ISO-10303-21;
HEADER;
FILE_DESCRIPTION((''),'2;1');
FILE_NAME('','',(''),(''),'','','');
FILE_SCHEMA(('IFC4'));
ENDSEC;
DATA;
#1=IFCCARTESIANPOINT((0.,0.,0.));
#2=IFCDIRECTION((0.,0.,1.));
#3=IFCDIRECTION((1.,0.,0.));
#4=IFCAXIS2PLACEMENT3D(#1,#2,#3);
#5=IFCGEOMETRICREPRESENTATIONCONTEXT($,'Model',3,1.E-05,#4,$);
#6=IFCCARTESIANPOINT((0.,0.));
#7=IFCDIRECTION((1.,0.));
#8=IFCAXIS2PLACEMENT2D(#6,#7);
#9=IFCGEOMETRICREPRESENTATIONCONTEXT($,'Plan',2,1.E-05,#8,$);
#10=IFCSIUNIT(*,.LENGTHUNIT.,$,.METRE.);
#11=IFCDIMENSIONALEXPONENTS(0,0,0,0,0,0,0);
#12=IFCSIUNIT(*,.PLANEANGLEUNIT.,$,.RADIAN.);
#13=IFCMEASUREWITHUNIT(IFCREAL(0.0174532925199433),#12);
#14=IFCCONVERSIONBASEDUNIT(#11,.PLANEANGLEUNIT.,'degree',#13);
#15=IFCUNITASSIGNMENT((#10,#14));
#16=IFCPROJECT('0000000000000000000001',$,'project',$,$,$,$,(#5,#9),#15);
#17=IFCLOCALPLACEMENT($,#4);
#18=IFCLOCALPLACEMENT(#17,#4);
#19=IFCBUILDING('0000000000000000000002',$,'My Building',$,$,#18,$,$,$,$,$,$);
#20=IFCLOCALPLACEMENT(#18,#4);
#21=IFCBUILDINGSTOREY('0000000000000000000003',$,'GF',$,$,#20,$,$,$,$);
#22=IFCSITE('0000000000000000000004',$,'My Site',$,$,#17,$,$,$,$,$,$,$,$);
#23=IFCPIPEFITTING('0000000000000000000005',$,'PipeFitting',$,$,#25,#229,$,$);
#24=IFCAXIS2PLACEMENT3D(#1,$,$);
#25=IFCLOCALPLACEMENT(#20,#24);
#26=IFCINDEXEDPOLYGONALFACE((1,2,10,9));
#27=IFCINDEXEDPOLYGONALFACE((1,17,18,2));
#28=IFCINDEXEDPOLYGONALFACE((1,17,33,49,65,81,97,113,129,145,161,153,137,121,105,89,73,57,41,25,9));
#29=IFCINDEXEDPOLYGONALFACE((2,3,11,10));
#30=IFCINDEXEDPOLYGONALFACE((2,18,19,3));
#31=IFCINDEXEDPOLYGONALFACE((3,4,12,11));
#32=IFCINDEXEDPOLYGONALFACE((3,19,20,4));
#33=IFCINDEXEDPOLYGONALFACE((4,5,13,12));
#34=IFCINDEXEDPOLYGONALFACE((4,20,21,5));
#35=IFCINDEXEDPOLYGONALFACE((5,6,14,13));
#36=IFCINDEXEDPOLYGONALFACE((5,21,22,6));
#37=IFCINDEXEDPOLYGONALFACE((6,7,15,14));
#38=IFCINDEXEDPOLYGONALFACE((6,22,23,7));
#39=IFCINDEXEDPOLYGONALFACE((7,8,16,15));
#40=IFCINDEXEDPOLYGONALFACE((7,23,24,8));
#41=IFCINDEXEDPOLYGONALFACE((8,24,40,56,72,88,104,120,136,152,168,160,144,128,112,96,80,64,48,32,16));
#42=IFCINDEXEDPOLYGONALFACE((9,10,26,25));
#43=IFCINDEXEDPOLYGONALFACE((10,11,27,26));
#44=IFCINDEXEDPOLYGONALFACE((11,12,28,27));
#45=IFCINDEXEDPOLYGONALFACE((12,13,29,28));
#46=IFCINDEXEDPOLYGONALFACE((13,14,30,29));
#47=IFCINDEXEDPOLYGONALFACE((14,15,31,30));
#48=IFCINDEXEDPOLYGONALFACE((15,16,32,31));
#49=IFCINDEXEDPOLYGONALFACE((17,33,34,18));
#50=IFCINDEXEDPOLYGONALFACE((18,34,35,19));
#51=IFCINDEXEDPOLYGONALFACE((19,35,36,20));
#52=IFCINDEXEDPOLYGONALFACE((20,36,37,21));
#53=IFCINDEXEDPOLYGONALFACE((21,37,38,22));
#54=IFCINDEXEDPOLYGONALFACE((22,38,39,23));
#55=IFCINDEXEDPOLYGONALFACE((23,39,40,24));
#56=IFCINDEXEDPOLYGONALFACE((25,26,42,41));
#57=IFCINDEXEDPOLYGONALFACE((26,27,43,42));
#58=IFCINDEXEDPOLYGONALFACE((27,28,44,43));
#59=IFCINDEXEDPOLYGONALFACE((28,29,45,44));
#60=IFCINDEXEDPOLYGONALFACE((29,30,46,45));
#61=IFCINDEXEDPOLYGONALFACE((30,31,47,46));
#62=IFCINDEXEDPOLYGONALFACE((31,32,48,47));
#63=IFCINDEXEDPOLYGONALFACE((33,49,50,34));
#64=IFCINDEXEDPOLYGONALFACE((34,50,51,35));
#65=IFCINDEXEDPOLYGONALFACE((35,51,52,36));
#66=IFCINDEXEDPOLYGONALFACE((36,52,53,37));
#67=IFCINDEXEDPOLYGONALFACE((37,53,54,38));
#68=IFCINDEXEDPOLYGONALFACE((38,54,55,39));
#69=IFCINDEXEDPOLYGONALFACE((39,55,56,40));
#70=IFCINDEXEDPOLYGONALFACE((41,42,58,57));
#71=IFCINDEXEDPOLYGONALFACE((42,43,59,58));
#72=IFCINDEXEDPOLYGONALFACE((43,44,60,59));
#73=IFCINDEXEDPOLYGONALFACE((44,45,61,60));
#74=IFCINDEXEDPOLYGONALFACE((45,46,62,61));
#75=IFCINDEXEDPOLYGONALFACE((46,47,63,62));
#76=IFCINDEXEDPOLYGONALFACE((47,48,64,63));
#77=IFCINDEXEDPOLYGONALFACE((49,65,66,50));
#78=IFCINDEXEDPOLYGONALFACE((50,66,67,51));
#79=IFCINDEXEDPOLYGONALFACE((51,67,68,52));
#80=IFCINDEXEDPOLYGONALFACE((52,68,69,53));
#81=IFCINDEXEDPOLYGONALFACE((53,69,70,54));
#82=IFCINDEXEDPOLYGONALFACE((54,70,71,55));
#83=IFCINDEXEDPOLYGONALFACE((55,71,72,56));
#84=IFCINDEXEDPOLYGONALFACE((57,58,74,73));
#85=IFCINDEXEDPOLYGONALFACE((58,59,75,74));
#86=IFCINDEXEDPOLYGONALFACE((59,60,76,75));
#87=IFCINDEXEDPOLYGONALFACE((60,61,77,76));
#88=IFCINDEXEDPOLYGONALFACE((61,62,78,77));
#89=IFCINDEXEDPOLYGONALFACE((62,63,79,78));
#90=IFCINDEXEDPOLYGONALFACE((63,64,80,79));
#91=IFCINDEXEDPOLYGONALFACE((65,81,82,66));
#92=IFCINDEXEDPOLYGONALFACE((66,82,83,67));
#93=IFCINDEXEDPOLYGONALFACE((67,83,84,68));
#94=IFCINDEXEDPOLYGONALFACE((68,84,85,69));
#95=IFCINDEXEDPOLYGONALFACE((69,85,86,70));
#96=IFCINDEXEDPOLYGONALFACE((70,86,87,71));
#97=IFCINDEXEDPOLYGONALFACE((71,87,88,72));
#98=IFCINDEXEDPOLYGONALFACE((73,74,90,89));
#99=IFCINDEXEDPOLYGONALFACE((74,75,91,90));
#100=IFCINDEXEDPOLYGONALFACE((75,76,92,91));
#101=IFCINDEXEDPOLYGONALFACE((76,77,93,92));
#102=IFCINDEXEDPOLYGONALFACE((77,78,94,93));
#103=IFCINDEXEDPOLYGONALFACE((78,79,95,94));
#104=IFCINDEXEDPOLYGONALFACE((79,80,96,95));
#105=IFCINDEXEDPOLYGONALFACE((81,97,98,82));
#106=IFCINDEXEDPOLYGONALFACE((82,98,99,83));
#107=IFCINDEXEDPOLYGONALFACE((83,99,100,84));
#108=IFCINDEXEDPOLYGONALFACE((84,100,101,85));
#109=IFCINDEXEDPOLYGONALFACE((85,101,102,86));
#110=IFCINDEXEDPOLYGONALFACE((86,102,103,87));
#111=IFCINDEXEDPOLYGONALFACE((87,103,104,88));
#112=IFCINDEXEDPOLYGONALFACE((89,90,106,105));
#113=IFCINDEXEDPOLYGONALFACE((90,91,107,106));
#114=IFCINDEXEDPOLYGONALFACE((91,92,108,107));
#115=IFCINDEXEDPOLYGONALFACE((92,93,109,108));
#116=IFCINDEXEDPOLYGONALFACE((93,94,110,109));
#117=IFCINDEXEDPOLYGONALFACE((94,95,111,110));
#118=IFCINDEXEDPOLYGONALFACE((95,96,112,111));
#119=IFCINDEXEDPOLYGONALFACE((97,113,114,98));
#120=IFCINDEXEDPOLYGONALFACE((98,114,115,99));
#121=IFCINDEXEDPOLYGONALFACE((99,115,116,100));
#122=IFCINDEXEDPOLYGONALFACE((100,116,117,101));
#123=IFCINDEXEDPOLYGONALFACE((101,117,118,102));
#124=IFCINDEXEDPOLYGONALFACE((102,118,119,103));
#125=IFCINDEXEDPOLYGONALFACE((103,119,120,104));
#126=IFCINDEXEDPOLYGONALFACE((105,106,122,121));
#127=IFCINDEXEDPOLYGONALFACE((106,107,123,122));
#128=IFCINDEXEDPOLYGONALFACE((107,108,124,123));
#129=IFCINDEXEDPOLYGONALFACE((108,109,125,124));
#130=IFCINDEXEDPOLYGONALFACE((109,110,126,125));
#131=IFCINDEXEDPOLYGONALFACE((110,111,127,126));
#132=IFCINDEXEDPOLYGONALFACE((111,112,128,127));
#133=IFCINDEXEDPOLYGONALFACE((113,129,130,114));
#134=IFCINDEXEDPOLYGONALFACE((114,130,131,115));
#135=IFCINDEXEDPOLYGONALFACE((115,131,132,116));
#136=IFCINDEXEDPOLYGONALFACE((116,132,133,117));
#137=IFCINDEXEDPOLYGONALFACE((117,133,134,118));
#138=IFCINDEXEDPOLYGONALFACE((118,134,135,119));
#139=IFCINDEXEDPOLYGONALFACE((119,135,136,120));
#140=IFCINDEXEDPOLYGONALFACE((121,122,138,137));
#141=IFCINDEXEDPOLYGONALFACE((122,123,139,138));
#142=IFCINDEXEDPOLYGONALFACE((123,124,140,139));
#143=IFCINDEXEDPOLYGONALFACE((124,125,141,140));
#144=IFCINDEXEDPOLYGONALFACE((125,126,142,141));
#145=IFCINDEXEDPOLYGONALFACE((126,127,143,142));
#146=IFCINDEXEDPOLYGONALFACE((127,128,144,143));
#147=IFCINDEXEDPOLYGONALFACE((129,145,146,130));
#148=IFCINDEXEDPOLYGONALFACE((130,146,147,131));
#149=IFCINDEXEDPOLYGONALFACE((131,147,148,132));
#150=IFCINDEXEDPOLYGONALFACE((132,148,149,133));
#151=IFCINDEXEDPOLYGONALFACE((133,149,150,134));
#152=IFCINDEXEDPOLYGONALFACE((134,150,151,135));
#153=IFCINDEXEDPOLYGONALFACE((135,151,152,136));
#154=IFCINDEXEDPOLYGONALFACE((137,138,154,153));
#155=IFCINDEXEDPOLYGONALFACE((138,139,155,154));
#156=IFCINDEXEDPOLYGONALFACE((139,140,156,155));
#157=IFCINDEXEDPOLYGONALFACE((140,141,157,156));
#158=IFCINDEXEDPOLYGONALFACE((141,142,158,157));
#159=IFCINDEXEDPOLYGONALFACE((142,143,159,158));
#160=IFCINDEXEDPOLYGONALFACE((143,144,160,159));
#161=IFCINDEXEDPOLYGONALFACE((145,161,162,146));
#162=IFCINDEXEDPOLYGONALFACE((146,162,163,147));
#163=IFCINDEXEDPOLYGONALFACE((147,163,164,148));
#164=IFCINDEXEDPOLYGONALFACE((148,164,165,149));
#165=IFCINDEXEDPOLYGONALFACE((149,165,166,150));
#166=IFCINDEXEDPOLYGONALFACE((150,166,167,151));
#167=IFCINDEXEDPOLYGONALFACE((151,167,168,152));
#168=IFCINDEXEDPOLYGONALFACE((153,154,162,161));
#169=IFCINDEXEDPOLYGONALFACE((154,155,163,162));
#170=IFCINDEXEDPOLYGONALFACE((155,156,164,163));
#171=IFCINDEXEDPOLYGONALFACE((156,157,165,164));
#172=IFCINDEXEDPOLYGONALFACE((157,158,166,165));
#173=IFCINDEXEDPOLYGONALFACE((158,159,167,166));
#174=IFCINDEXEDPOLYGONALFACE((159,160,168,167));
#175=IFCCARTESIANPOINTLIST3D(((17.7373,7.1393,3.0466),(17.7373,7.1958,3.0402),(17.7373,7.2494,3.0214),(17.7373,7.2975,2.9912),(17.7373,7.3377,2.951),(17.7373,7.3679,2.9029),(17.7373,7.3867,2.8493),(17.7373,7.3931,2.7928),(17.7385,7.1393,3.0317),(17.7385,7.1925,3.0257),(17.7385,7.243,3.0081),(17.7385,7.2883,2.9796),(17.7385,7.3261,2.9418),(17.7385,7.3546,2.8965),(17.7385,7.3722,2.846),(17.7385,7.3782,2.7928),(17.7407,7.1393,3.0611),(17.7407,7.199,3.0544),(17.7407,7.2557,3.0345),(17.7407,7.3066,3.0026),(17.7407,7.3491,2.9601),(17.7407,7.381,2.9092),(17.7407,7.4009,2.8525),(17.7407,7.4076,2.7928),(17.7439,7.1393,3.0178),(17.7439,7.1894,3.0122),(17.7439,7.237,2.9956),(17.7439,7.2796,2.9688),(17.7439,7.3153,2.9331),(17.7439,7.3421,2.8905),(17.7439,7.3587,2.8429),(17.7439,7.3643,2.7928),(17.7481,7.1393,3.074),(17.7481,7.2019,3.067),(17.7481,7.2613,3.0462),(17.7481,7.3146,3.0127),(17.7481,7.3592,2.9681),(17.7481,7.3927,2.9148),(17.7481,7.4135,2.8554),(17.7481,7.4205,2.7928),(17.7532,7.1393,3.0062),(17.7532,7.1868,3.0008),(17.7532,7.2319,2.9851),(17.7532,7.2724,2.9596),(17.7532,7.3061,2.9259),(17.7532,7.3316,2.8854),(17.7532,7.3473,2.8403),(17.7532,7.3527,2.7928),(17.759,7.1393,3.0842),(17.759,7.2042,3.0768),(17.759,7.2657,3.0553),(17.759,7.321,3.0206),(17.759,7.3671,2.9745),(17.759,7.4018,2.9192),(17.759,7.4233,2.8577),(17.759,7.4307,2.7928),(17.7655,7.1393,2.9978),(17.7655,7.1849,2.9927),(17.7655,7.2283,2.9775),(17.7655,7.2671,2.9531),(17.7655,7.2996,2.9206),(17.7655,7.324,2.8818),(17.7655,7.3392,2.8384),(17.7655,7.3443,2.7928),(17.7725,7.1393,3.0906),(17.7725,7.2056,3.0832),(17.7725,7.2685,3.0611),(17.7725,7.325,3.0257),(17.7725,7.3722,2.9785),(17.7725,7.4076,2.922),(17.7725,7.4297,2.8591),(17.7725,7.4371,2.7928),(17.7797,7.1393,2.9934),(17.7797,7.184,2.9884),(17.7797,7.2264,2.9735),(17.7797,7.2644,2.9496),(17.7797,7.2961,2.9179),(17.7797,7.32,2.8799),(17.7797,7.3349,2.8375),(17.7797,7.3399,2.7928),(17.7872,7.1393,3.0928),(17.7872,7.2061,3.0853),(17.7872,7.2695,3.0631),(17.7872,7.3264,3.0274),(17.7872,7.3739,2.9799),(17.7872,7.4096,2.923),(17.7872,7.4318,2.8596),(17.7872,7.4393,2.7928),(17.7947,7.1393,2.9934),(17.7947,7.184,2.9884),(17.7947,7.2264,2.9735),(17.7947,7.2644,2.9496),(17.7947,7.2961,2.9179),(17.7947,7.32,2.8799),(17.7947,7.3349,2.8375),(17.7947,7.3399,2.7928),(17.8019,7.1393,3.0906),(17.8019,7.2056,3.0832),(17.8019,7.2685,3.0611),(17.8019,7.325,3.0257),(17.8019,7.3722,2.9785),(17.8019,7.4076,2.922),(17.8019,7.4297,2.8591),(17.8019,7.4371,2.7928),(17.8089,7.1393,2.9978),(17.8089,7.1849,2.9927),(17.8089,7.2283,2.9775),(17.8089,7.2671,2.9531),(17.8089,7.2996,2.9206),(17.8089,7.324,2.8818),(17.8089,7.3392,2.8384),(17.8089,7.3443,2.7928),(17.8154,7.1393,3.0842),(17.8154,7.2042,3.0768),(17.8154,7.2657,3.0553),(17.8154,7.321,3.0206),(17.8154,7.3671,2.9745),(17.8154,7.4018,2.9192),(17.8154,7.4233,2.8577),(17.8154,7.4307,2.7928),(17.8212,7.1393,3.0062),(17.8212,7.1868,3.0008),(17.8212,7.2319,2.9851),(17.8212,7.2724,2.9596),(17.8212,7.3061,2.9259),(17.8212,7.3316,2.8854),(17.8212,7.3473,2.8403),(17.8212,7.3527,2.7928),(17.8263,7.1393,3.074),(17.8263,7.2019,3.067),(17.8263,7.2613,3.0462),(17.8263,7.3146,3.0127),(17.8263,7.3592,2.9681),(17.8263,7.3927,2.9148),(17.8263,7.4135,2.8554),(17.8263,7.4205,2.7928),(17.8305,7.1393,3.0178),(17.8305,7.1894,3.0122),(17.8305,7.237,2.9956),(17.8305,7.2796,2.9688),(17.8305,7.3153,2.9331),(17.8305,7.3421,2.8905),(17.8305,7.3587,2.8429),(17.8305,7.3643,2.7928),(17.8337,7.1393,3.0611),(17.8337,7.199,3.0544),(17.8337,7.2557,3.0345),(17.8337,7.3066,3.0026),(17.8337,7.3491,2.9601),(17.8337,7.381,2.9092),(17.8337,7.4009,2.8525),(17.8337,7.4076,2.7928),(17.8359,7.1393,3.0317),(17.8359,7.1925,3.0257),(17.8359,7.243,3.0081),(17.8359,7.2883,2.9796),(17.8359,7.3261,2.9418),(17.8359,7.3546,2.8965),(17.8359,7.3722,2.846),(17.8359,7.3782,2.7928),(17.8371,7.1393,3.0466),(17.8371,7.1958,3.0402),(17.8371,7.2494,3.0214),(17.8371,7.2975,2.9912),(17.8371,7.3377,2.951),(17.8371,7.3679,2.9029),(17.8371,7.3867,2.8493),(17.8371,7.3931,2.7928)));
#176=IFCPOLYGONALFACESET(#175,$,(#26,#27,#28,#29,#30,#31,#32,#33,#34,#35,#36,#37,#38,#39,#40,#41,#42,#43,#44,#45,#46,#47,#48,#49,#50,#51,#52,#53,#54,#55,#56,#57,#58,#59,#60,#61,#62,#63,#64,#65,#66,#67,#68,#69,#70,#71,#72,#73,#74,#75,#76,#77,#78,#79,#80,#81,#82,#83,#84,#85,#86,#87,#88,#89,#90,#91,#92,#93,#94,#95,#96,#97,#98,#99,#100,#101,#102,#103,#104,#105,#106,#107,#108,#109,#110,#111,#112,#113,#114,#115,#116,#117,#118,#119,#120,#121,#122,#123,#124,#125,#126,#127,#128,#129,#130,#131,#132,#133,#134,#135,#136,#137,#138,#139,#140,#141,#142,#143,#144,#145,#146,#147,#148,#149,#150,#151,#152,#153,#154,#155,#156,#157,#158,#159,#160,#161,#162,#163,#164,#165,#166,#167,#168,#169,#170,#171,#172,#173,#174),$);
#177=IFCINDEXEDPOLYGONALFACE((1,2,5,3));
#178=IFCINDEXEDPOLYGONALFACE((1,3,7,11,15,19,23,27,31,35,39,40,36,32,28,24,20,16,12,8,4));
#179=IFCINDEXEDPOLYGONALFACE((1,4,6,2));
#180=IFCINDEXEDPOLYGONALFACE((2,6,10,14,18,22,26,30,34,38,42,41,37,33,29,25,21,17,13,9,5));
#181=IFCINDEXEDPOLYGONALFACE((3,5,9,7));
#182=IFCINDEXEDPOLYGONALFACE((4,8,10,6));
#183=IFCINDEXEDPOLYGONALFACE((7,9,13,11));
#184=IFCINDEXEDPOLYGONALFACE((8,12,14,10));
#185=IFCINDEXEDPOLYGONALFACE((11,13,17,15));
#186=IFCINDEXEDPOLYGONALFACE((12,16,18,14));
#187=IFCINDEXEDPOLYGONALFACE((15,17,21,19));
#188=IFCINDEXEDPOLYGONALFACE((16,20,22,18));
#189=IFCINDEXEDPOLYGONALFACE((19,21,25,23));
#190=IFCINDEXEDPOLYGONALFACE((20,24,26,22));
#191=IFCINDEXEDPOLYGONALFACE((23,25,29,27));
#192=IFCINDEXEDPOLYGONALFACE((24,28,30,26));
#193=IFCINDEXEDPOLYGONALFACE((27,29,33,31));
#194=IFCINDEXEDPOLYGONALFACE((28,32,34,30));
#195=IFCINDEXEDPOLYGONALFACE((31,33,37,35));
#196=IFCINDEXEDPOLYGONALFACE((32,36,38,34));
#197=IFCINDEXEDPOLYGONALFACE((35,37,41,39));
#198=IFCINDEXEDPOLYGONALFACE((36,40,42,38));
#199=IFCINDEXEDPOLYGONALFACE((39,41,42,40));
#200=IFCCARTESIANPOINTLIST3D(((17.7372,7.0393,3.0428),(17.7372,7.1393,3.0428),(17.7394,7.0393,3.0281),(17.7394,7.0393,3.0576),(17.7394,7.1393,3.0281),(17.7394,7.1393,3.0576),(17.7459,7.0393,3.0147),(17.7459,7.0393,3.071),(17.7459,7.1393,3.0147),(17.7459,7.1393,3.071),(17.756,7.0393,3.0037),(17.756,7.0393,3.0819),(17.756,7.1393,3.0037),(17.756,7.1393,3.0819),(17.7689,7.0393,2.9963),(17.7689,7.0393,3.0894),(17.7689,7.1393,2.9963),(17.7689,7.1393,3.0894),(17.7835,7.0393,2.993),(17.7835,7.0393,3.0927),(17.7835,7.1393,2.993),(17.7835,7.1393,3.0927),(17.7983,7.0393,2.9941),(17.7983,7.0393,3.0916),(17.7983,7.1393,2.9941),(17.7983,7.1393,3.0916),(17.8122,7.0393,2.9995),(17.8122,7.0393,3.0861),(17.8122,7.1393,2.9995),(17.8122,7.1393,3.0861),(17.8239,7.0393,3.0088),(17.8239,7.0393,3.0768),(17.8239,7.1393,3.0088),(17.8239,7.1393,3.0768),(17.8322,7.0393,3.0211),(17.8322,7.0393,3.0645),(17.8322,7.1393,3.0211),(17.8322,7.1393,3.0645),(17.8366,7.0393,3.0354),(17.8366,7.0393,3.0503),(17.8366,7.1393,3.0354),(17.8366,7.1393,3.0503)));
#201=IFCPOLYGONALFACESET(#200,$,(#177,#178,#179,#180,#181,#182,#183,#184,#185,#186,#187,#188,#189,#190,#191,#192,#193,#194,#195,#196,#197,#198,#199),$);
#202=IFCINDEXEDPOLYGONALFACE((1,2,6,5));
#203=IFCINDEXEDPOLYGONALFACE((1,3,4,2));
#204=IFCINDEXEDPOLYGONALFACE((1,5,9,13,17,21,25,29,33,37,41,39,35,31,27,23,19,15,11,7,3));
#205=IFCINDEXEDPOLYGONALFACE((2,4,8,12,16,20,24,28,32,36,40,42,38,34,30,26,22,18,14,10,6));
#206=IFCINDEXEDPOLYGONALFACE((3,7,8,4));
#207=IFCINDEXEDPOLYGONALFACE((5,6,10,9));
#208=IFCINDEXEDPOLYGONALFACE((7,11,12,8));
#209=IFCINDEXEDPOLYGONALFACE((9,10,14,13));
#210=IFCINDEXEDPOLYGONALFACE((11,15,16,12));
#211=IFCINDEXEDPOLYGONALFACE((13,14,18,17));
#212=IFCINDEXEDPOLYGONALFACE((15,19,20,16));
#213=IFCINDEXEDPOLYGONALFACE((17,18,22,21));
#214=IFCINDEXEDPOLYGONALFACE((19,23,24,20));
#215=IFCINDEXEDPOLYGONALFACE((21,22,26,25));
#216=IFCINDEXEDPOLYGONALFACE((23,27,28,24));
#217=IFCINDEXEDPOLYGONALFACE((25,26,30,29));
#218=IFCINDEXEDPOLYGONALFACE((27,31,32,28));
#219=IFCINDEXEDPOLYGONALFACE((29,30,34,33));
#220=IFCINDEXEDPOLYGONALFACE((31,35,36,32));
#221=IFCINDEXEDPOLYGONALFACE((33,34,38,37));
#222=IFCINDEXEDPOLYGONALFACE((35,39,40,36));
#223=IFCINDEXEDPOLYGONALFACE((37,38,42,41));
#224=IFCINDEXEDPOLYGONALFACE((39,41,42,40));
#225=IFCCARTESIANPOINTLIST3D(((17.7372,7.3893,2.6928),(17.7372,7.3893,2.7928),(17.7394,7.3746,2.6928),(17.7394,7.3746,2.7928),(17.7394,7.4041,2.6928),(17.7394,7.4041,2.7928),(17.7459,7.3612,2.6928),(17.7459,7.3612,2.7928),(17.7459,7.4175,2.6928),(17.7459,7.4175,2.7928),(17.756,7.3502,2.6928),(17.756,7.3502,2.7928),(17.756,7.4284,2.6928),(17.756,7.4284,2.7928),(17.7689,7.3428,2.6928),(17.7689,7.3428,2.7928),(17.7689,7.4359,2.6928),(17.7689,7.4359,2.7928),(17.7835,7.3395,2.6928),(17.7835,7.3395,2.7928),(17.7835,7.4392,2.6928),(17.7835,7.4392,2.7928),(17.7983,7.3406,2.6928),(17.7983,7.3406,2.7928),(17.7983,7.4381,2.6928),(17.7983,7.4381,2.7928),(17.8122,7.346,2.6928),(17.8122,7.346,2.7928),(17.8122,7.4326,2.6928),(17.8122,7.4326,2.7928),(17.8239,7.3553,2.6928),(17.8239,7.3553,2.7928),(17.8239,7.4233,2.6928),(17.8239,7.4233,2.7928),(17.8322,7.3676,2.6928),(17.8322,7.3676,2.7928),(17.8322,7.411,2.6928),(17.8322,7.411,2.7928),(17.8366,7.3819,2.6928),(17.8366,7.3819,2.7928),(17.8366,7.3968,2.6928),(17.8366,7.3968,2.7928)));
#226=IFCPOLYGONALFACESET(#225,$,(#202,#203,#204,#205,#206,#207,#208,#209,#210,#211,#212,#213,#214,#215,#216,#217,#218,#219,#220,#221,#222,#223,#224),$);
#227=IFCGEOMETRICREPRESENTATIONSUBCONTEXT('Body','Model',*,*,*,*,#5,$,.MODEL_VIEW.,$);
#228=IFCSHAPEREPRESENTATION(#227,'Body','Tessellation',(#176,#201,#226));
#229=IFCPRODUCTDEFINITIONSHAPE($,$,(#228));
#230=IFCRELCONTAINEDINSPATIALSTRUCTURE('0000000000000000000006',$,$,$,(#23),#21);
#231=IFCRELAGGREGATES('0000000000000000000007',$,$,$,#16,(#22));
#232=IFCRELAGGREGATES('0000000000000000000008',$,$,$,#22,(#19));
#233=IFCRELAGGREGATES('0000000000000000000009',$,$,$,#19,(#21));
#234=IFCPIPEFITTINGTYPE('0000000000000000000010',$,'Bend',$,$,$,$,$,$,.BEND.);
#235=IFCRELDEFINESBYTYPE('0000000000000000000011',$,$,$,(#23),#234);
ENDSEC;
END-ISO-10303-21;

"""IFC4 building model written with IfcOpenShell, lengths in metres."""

from ifc_helpers import new_model, entity, si_unit, converted_unit, frame, origin_with_axes, origin_2d_with_axis, place, context, subcontext, project, spatial, line, indexed_curve, circle, outline, extrude, source, transform, mapped, type_object, type_shapes, element, save


model = new_model("IFC4")

# Units and contexts
model_context = context("Model", 3, precision=1e-05, world=origin_with_axes())
plan_context = context("Plan", 2, precision=1e-05, world=origin_2d_with_axis())
body_context_1 = subcontext(model_context, "Body", "Model", "MODEL_VIEW")
ifc_project = project(units=[si_unit("LENGTHUNIT", "METRE"), converted_unit("PLANEANGLEUNIT", "degree", entity("IfcReal", 0.0174532925199433), si_unit("PLANEANGLEUNIT", "RADIAN"), dimensions=[0, 0, 0, 0, 0, 0, 0])], contexts=[model_context, plan_context])

# Site, building, storey
site_placement = place(None, origin_with_axes())
site = spatial("IfcSite", under=ifc_project, at=site_placement, Name="My Site")
building_placement = place(site_placement, origin_with_axes())
building = spatial("IfcBuilding", under=site, at=building_placement, Name="My Building")
storey_placement = place(building_placement, origin_with_axes())
storey = spatial("IfcBuildingStorey", under=building, at=storey_placement, Name="GF")

# Pipe fitting, opening
pipe_fitting_type = type_object("IfcPipeFittingType", Name="Bend", PredefinedType="BEND")
shared_shape_1 = source(origin_with_axes(), body_context_1, "Body", "SolidModel", [
    entity("IfcSweptDiskSolid", entity("IfcIndexedPolyCurve", entity("IfcCartesianPointList3D", [[0.0, 0.0, 0.1], [0.0, -0.0732, 0.2768], [0.0, -0.25, 0.35]]), [entity("IfcArcIndex", [1, 2, 3])]), 0.05),
    extrude(circle(Radius=0.05), origin_with_axes(), (0.0, 0.0, 1.0), 0.1),
    extrude(circle(Radius=0.05), frame((0.0, -0.25, 0.35), z_axis=(0.0, -1.0, 0.0), x_axis=(1.0, 0.0, 0.0)), (0.0, 0.0, 1.0), 0.1),
])
type_shapes(pipe_fitting_type, [shared_shape_1])
pipe_fitting_1_placement = place(storey_placement, frame((17.7872, 7.0393, 3.0428), z_axis=(0.0, 1.0, 0.0), x_axis=(-1.0, 0.0, 0.0)))
pipe_fitting_1 = element("IfcPipeFitting", 1, at=pipe_fitting_1_placement, inside=storey, type_object=pipe_fitting_type, Name="PipeFitting", context=body_context_1, shape_type="MappedRepresentation", body=[
    mapped(shared_shape_1, transform((0.0, 0.0, 0.0), x_axis=(1.0, 0.0, 0.0), y_axis=(0.0, 1.0, 0.0), z_axis=(0.0, 0.0, 1.0), scale=1.0)),
])
opening_1_placement = place(pipe_fitting_1_placement, frame((17.7872, -3.0428, -7.0393), z_axis=(0.0, 1.0, 0.0), x_axis=(-1.0, 0.0, 0.0)))
element("IfcOpeningElement", 2, at=opening_1_placement, cuts=pipe_fitting_1, PredefinedType="OPENING", context=body_context_1, shape_type="SweptSolid", body=[
    extrude(outline(indexed_curve([(0.0, 0.0), (0.5, 0.0), (0.5, 0.5), (0.0, 0.5)], segments=[line(1, 2, 3, 4, 1)])), origin_with_axes(), (0.0, 0.0, 1.0), 0.5),
])

save(model, "model.ifc")
